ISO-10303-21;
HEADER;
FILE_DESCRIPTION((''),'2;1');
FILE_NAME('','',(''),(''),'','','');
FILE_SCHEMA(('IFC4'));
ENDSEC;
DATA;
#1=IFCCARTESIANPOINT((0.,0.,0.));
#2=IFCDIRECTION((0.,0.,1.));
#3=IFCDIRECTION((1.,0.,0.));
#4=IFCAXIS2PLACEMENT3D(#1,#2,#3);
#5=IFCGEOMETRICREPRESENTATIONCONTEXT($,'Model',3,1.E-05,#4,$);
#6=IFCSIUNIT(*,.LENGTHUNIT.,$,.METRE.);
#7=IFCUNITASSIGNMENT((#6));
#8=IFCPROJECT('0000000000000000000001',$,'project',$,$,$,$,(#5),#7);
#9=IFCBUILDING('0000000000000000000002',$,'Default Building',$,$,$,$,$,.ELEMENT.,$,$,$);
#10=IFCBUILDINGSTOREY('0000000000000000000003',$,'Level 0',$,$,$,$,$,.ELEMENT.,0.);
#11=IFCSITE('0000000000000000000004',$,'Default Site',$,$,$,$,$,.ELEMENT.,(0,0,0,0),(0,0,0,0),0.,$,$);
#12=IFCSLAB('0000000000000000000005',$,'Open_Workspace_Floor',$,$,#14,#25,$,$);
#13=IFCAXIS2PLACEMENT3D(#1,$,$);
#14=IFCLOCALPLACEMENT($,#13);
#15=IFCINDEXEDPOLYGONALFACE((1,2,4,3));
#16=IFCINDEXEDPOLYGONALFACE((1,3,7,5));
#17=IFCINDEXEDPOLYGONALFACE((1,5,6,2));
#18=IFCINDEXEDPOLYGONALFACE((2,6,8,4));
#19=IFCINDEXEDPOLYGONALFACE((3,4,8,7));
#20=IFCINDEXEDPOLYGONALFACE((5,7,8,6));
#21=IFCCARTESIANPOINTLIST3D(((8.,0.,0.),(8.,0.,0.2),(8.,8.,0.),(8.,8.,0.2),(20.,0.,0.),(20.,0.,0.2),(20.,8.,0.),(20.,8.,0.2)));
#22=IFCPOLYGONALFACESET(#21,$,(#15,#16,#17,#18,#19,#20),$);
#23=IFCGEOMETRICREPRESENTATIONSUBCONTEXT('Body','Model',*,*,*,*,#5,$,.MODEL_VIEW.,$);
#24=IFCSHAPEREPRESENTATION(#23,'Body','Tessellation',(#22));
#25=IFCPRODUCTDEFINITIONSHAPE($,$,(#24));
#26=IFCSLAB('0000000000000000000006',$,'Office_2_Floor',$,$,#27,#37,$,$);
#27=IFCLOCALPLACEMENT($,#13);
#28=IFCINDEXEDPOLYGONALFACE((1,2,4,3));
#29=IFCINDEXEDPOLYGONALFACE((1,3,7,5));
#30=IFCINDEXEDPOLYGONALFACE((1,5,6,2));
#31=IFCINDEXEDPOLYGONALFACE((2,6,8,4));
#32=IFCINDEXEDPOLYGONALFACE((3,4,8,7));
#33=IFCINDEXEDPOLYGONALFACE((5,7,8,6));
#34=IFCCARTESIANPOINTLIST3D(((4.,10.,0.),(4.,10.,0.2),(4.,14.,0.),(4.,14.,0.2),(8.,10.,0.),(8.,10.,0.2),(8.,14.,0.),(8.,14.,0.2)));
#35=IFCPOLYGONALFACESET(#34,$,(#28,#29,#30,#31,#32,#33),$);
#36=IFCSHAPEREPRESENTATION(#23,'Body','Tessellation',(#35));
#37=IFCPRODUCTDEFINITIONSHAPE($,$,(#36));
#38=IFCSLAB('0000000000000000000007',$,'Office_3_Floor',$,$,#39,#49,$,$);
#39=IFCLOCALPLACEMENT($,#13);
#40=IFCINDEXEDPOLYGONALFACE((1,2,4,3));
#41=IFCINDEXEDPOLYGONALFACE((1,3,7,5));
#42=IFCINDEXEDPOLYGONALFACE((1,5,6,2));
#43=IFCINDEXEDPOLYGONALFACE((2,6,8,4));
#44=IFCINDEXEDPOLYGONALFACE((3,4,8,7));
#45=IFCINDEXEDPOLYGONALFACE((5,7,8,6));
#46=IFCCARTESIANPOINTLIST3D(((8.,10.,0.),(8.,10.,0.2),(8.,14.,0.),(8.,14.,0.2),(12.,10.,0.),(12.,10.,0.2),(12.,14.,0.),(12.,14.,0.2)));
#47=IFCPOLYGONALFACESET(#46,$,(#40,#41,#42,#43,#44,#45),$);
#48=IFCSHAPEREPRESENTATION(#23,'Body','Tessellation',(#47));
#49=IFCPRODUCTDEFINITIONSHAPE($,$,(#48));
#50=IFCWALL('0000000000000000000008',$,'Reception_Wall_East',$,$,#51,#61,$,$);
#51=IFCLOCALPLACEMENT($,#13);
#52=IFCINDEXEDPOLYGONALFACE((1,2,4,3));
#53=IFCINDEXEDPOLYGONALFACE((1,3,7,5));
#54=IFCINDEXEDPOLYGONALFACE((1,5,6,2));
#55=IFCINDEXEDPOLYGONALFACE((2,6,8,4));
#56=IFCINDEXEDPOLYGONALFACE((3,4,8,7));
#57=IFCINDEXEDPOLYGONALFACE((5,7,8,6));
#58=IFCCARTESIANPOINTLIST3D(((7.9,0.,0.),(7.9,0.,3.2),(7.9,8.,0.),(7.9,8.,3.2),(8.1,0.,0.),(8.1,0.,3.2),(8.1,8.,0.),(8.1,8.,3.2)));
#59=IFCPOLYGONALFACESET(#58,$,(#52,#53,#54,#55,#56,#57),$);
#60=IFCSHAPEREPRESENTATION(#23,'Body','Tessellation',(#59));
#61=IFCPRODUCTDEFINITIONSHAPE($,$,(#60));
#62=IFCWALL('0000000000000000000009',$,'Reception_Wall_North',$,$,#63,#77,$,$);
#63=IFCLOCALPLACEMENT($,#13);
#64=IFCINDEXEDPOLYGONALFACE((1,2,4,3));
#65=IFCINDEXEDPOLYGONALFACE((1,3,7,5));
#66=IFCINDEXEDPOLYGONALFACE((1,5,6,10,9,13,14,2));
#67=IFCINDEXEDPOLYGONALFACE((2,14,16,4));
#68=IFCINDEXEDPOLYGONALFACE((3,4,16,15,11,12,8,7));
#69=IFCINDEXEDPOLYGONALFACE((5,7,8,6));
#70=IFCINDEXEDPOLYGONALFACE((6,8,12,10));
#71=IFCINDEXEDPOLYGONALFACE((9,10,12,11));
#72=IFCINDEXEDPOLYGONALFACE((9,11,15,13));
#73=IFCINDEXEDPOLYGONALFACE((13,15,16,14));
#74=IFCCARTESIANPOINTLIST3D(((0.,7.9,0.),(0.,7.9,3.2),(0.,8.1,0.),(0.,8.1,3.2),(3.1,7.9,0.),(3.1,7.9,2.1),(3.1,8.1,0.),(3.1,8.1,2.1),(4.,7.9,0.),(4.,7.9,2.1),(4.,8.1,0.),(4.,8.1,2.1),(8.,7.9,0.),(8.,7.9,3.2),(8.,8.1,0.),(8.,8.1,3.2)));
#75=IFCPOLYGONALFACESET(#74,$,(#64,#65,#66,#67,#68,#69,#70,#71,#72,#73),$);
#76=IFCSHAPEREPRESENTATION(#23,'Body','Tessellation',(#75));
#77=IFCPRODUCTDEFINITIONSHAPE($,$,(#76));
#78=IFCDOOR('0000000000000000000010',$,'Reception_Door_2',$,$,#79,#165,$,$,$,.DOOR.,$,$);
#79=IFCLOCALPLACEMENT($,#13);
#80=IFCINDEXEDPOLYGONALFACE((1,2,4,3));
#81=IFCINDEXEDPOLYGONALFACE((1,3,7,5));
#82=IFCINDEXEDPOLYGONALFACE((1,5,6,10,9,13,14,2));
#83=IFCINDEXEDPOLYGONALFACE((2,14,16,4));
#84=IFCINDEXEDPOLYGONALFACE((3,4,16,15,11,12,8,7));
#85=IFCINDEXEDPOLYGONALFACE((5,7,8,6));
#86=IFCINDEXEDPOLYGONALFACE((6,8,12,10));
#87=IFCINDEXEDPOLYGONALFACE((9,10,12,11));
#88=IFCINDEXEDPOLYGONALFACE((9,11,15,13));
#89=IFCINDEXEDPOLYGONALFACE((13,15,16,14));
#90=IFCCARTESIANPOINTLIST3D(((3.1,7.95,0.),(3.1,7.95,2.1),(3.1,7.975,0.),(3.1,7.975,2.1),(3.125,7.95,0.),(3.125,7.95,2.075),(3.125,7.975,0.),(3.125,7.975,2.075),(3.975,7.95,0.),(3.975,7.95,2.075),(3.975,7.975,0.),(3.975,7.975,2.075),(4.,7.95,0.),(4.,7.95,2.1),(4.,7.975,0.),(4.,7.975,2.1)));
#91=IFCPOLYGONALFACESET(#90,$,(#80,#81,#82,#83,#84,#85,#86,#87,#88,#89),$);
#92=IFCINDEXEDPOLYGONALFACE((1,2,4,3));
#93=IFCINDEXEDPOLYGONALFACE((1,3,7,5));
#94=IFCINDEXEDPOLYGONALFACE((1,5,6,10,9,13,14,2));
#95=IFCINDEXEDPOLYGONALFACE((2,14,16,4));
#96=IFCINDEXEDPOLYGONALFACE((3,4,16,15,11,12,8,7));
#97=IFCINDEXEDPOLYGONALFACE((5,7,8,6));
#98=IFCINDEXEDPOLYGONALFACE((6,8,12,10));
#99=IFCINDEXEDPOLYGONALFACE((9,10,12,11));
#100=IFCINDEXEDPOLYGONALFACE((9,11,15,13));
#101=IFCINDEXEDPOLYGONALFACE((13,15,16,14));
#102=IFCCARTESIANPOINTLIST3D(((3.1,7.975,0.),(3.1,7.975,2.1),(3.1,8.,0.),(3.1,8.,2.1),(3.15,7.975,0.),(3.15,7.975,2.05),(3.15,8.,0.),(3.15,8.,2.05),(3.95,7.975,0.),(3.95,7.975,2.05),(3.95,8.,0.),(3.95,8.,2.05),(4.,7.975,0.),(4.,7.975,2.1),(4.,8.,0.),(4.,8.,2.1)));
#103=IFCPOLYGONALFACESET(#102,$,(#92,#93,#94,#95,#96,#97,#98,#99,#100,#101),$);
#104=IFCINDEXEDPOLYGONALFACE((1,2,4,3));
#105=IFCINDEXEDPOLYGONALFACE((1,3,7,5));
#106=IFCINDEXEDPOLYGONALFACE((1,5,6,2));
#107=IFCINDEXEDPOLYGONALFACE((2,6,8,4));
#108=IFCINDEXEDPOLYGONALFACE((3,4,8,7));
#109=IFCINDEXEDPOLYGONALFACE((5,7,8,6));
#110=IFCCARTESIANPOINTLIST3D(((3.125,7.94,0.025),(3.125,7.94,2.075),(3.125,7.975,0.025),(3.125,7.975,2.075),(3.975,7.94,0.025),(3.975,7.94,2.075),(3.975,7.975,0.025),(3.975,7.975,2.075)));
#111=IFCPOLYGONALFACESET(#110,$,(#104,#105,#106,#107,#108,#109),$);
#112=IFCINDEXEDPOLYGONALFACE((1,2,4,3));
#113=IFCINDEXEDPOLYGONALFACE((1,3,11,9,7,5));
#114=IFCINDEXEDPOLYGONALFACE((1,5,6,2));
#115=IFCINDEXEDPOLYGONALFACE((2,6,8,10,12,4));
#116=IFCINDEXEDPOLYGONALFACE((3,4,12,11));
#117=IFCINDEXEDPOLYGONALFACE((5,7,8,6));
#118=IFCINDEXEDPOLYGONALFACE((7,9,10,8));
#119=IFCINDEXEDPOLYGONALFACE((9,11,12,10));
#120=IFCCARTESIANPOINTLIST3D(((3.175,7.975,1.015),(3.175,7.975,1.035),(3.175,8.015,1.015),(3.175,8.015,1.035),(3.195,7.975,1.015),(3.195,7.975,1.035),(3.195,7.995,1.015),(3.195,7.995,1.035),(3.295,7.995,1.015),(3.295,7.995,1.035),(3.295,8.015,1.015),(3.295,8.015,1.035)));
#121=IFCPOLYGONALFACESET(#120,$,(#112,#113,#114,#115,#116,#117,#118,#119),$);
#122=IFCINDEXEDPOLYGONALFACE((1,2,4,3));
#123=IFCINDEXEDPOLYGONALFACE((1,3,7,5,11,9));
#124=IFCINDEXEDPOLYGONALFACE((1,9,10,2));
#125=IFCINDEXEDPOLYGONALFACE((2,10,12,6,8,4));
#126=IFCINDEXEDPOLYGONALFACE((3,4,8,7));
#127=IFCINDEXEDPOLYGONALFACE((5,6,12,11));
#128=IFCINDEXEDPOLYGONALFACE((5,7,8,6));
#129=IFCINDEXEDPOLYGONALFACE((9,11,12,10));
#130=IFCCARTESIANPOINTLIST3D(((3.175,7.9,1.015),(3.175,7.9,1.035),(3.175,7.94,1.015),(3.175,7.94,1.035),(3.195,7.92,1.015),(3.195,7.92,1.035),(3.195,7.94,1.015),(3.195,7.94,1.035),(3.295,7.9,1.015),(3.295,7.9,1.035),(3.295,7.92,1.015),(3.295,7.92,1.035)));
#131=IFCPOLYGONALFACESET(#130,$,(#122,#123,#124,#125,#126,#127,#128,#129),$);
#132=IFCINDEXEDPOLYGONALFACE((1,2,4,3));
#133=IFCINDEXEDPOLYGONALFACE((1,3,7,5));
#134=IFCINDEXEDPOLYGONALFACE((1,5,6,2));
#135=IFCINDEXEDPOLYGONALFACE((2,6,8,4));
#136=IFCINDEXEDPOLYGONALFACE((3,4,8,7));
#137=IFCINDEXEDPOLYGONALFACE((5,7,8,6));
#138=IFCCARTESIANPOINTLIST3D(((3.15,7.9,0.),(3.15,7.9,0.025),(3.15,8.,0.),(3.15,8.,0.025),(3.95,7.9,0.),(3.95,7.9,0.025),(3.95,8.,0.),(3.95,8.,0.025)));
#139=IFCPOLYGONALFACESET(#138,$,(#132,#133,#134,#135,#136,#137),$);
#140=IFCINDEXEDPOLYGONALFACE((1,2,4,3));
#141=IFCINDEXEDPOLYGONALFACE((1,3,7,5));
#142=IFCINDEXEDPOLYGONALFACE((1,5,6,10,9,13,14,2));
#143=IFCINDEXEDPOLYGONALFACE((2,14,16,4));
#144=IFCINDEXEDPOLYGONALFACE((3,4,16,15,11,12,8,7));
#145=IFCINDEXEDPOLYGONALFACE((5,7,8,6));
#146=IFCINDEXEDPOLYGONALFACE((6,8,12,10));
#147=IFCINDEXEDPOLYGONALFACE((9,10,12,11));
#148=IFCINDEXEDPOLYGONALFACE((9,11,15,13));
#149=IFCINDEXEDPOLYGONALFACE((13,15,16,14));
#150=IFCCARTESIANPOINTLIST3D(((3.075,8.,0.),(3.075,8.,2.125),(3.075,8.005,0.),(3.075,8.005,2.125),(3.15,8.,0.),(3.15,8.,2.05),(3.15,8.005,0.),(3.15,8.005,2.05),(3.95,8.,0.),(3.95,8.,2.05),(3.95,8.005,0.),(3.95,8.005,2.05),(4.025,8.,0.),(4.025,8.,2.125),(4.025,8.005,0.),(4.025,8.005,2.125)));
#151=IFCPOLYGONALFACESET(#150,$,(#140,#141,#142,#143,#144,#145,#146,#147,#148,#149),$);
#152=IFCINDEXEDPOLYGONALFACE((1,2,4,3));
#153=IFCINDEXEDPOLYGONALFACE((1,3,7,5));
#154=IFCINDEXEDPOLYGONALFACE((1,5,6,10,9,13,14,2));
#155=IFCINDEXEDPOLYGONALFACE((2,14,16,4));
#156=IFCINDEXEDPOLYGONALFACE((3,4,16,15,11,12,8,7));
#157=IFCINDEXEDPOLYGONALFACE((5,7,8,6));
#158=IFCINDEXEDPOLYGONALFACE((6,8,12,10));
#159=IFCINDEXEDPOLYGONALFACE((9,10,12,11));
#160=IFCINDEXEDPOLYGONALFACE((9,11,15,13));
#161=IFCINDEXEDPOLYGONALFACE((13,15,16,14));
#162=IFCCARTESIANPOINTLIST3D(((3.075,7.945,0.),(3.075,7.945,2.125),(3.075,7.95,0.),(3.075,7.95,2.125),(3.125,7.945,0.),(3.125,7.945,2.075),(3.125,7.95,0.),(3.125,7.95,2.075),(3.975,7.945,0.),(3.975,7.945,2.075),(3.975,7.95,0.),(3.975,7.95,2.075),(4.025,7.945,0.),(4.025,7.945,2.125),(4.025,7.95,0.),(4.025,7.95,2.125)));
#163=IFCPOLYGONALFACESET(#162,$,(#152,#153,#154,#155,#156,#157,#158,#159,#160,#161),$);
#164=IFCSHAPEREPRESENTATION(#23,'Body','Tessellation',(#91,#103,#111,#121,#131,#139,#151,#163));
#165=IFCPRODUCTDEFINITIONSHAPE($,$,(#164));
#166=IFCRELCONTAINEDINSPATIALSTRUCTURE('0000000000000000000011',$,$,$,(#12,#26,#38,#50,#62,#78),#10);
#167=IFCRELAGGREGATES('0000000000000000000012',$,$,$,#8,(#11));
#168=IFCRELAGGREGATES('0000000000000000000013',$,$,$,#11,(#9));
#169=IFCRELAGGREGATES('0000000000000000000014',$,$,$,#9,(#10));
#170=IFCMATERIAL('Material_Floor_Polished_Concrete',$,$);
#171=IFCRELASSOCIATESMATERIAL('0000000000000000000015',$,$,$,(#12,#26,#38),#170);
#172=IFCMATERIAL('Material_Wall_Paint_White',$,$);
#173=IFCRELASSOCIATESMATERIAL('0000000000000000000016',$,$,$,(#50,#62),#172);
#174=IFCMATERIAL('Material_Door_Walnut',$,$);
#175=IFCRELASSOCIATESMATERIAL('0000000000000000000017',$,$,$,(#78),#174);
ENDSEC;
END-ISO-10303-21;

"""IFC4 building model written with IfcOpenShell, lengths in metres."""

from ifc_helpers import new_model, si_unit, frame, origin_with_axes, place, context, subcontext, project, spatial, line, indexed_curve, outline, extrude, material, element, fill, save


model = new_model("IFC4")

# Units and contexts
model_context = context("Model", 3, precision=1e-05, world=origin_with_axes())
body_context = subcontext(model_context, "Body", "Model", "MODEL_VIEW")
ifc_project = project(units=[si_unit("LENGTHUNIT", "METRE")], contexts=[model_context])

# Site, building, storey
site = spatial("IfcSite", under=ifc_project, Name="Default Site", CompositionType="ELEMENT", RefLatitude=(0, 0, 0, 0), RefLongitude=(0, 0, 0, 0), RefElevation=0.0)
building = spatial("IfcBuilding", under=site, Name="Default Building", CompositionType="ELEMENT")
storey = spatial("IfcBuildingStorey", under=building, Name="Level 0", CompositionType="ELEMENT", Elevation=0.0)

# Slabs
ifc_material_1 = material(Name="Material_Floor_Polished_Concrete")
slab_placement = place(None, frame((8.0, 0.0, 0.0), z_axis=(0.0, 0.0, 1.0), x_axis=(1.0, 0.0, 0.0)))
element("IfcSlab", 1, at=slab_placement, inside=storey, material=ifc_material_1, Name="Open_Workspace_Floor", context=body_context, shape_type="SweptSolid", body=[
    extrude(outline(indexed_curve([(0.0, 0.0), (12.0, 0.0), (12.0, 8.0), (0.0, 8.0)])), None, (0.0, 0.0, 1.0), 0.2),
])
for number, where, z_axis, x_axis, name in (
    (2, (4.0, 10.0, 0.0), (0.0, 0.0, 1.0), (1.0, 0.0, 0.0), "Office_2_Floor"),
    (3, (8.0, 10.0, 0.0), (0.0, 0.0, 1.0), (1.0, 0.0, 0.0), "Office_3_Floor"),
):
    element("IfcSlab", number, at=place(None, frame(where, z_axis=z_axis, x_axis=x_axis)), inside=storey, material=ifc_material_1, Name=name, context=body_context, shape_type="SweptSolid", body=[
        extrude(outline(indexed_curve([(0.0, 0.0), (4.0, 0.0), (4.0, 4.0), (0.0, 4.0)])), None, (0.0, 0.0, 1.0), 0.2),
    ])

# Wall
ifc_material_2 = material(Name="Material_Wall_Paint_White")
wall_1_placement = place(None, frame((8.0, 0.0, 0.0), z_axis=(0.0, 0.0, 1.0), x_axis=(0.0, 1.0, 0.0)))
element("IfcWall", 4, at=wall_1_placement, inside=storey, material=ifc_material_2, Name="Reception_Wall_East", context=body_context, shape_type="SweptSolid", body=[
    extrude(outline(indexed_curve([(0.0, 0.0), (0.0, 0.2), (8.0, 0.2), (8.0, 0.0), (0.0, 0.0)], self_intersect=False)), frame((0.0, -0.1, 0.0), z_axis=(0.0, 0.0, 1.0), x_axis=(1.0, 0.0, 0.0)), (0.0, 0.0, 1.0), 3.2),
])

# Wall, opening, door
wall_2_placement = place(None, frame((8.0, 8.0, 0.0), z_axis=(0.0, 0.0, 1.0), x_axis=(-1.0, 0.0, 0.0)))
wall_2 = element("IfcWall", 5, at=wall_2_placement, inside=storey, material=ifc_material_2, Name="Reception_Wall_North", context=body_context, shape_type="SweptSolid", body=[
    extrude(outline(indexed_curve([(0.0, 0.0), (0.0, 0.2), (8.0, 0.2), (8.0, 0.0), (0.0, 0.0)], self_intersect=False)), frame((0.0, -0.1, 0.0), z_axis=(0.0, 0.0, 1.0), x_axis=(1.0, 0.0, 0.0)), (0.0, 0.0, 1.0), 3.2),
])
opening_1_placement = place(wall_2_placement, frame((4.0, -0.5, 0.0), z_axis=(0.0, 0.0, 1.0), x_axis=(1.0, 0.0, 0.0)))
opening_1 = element("IfcOpeningElement", 6, at=opening_1_placement, inside=storey, cuts=wall_2, PredefinedType="OPENING", context=body_context, shape_type="SweptSolid", body=[
    extrude(outline(indexed_curve([(0.0, 0.0), (0.0, 1.0), (0.9, 1.0), (0.9, 0.0), (0.0, 0.0)], self_intersect=False)), origin_with_axes(), (0.0, 0.0, 1.0), 2.1),
])
ifc_material_3 = material(Name="Material_Door_Walnut")
door_1_placement = place(None, frame((4.0, 8.0, 0.0), z_axis=(0.0, 0.0, 1.0), x_axis=(-1.0, 0.0, 0.0)))
door_1 = element("IfcDoor", 7, at=door_1_placement, inside=storey, material=ifc_material_3, Name="Reception_Door_2", PredefinedType="DOOR", context=body_context, shape_type="SweptSolid", body=[
    extrude(outline(indexed_curve([(0.0, 0.0), (0.0, 2.1), (0.9, 2.1), (0.9, 0.0), (0.875, 0.0), (0.875, 2.075), (0.025, 2.075), (0.025, 0.0)], segments=[line(1, 2, 3, 4, 5, 6, 7, 8, 1)])), frame((0.0, 0.025, 0.0), z_axis=(0.0, -1.0, 0.0), x_axis=(1.0, 0.0, 0.0)), (0.0, 0.0, -1.0), 0.025),
    extrude(outline(indexed_curve([(0.0, 0.0), (0.0, 2.1), (0.9, 2.1), (0.9, 0.0), (0.85, 0.0), (0.85, 2.05), (0.05, 2.05), (0.05, 0.0)], segments=[line(1, 2, 3, 4, 5, 6, 7, 8, 1)])), frame((0.0, 0.0, 0.0), z_axis=(0.0, -1.0, 0.0), x_axis=(1.0, 0.0, 0.0)), (0.0, 0.0, -1.0), 0.025),
    extrude(outline(indexed_curve([(0.0, 0.0), (0.85, 0.0), (0.85, 0.035), (0.0, 0.035)], segments=[line(1, 2, 3, 4, 1)])), frame((0.025, 0.025, 0.025), z_axis=(0.0, 0.0, 1.0), x_axis=(1.0, 0.0, 0.0)), (0.0, 0.0, 1.0), 2.05),
    extrude(outline(indexed_curve([(0.0, 0.0), (0.0, -0.04), (-0.12, -0.04), (-0.12, -0.02), (-0.02, -0.02), (-0.02, 0.0)], segments=[line(1, 2, 3, 4, 5, 6, 1)])), frame((0.825, 0.025, 1.015), z_axis=(0.0, 0.0, 1.0), x_axis=(1.0, 0.0, 0.0)), (0.0, 0.0, 1.0), 0.02),
    extrude(outline(indexed_curve([(0.0, 0.0), (0.0, 0.04), (-0.12, 0.04), (-0.12, 0.02), (-0.02, 0.02), (-0.02, 0.0)], segments=[line(1, 2, 3, 4, 5, 6, 1)])), frame((0.825, 0.06, 1.015), z_axis=(0.0, 0.0, 1.0), x_axis=(1.0, 0.0, 0.0)), (0.0, 0.0, 1.0), 0.02),
    extrude(outline(indexed_curve([(0.0, 0.0), (0.8, 0.0), (0.8, 0.1), (0.0, 0.1)], segments=[line(1, 2, 3, 4, 1)])), frame((0.05, 0.0, 0.0), z_axis=(0.0, 0.0, 1.0), x_axis=(1.0, 0.0, 0.0)), (0.0, 0.0, 1.0), 0.025),
    extrude(outline(indexed_curve([(0.0, 0.0), (0.0, 2.125), (0.95, 2.125), (0.95, 0.0), (0.875, 0.0), (0.875, 2.05), (0.075, 2.05), (0.075, 0.0)], segments=[line(1, 2, 3, 4, 5, 6, 7, 8, 1)])), frame((-0.025, -0.005, 0.0), z_axis=(0.0, -1.0, 0.0), x_axis=(1.0, 0.0, 0.0)), (0.0, 0.0, -1.0), 0.005),
    extrude(outline(indexed_curve([(0.0, 0.0), (0.0, 2.125), (0.95, 2.125), (0.95, 0.0), (0.9, 0.0), (0.9, 2.075), (0.05, 2.075), (0.05, 0.0)], segments=[line(1, 2, 3, 4, 5, 6, 7, 8, 1)])), frame((-0.025, 0.05, 0.0), z_axis=(0.0, -1.0, 0.0), x_axis=(1.0, 0.0, 0.0)), (0.0, 0.0, -1.0), 0.005),
])
fill(opening_1, door_1)

save(model, "model.ifc")
